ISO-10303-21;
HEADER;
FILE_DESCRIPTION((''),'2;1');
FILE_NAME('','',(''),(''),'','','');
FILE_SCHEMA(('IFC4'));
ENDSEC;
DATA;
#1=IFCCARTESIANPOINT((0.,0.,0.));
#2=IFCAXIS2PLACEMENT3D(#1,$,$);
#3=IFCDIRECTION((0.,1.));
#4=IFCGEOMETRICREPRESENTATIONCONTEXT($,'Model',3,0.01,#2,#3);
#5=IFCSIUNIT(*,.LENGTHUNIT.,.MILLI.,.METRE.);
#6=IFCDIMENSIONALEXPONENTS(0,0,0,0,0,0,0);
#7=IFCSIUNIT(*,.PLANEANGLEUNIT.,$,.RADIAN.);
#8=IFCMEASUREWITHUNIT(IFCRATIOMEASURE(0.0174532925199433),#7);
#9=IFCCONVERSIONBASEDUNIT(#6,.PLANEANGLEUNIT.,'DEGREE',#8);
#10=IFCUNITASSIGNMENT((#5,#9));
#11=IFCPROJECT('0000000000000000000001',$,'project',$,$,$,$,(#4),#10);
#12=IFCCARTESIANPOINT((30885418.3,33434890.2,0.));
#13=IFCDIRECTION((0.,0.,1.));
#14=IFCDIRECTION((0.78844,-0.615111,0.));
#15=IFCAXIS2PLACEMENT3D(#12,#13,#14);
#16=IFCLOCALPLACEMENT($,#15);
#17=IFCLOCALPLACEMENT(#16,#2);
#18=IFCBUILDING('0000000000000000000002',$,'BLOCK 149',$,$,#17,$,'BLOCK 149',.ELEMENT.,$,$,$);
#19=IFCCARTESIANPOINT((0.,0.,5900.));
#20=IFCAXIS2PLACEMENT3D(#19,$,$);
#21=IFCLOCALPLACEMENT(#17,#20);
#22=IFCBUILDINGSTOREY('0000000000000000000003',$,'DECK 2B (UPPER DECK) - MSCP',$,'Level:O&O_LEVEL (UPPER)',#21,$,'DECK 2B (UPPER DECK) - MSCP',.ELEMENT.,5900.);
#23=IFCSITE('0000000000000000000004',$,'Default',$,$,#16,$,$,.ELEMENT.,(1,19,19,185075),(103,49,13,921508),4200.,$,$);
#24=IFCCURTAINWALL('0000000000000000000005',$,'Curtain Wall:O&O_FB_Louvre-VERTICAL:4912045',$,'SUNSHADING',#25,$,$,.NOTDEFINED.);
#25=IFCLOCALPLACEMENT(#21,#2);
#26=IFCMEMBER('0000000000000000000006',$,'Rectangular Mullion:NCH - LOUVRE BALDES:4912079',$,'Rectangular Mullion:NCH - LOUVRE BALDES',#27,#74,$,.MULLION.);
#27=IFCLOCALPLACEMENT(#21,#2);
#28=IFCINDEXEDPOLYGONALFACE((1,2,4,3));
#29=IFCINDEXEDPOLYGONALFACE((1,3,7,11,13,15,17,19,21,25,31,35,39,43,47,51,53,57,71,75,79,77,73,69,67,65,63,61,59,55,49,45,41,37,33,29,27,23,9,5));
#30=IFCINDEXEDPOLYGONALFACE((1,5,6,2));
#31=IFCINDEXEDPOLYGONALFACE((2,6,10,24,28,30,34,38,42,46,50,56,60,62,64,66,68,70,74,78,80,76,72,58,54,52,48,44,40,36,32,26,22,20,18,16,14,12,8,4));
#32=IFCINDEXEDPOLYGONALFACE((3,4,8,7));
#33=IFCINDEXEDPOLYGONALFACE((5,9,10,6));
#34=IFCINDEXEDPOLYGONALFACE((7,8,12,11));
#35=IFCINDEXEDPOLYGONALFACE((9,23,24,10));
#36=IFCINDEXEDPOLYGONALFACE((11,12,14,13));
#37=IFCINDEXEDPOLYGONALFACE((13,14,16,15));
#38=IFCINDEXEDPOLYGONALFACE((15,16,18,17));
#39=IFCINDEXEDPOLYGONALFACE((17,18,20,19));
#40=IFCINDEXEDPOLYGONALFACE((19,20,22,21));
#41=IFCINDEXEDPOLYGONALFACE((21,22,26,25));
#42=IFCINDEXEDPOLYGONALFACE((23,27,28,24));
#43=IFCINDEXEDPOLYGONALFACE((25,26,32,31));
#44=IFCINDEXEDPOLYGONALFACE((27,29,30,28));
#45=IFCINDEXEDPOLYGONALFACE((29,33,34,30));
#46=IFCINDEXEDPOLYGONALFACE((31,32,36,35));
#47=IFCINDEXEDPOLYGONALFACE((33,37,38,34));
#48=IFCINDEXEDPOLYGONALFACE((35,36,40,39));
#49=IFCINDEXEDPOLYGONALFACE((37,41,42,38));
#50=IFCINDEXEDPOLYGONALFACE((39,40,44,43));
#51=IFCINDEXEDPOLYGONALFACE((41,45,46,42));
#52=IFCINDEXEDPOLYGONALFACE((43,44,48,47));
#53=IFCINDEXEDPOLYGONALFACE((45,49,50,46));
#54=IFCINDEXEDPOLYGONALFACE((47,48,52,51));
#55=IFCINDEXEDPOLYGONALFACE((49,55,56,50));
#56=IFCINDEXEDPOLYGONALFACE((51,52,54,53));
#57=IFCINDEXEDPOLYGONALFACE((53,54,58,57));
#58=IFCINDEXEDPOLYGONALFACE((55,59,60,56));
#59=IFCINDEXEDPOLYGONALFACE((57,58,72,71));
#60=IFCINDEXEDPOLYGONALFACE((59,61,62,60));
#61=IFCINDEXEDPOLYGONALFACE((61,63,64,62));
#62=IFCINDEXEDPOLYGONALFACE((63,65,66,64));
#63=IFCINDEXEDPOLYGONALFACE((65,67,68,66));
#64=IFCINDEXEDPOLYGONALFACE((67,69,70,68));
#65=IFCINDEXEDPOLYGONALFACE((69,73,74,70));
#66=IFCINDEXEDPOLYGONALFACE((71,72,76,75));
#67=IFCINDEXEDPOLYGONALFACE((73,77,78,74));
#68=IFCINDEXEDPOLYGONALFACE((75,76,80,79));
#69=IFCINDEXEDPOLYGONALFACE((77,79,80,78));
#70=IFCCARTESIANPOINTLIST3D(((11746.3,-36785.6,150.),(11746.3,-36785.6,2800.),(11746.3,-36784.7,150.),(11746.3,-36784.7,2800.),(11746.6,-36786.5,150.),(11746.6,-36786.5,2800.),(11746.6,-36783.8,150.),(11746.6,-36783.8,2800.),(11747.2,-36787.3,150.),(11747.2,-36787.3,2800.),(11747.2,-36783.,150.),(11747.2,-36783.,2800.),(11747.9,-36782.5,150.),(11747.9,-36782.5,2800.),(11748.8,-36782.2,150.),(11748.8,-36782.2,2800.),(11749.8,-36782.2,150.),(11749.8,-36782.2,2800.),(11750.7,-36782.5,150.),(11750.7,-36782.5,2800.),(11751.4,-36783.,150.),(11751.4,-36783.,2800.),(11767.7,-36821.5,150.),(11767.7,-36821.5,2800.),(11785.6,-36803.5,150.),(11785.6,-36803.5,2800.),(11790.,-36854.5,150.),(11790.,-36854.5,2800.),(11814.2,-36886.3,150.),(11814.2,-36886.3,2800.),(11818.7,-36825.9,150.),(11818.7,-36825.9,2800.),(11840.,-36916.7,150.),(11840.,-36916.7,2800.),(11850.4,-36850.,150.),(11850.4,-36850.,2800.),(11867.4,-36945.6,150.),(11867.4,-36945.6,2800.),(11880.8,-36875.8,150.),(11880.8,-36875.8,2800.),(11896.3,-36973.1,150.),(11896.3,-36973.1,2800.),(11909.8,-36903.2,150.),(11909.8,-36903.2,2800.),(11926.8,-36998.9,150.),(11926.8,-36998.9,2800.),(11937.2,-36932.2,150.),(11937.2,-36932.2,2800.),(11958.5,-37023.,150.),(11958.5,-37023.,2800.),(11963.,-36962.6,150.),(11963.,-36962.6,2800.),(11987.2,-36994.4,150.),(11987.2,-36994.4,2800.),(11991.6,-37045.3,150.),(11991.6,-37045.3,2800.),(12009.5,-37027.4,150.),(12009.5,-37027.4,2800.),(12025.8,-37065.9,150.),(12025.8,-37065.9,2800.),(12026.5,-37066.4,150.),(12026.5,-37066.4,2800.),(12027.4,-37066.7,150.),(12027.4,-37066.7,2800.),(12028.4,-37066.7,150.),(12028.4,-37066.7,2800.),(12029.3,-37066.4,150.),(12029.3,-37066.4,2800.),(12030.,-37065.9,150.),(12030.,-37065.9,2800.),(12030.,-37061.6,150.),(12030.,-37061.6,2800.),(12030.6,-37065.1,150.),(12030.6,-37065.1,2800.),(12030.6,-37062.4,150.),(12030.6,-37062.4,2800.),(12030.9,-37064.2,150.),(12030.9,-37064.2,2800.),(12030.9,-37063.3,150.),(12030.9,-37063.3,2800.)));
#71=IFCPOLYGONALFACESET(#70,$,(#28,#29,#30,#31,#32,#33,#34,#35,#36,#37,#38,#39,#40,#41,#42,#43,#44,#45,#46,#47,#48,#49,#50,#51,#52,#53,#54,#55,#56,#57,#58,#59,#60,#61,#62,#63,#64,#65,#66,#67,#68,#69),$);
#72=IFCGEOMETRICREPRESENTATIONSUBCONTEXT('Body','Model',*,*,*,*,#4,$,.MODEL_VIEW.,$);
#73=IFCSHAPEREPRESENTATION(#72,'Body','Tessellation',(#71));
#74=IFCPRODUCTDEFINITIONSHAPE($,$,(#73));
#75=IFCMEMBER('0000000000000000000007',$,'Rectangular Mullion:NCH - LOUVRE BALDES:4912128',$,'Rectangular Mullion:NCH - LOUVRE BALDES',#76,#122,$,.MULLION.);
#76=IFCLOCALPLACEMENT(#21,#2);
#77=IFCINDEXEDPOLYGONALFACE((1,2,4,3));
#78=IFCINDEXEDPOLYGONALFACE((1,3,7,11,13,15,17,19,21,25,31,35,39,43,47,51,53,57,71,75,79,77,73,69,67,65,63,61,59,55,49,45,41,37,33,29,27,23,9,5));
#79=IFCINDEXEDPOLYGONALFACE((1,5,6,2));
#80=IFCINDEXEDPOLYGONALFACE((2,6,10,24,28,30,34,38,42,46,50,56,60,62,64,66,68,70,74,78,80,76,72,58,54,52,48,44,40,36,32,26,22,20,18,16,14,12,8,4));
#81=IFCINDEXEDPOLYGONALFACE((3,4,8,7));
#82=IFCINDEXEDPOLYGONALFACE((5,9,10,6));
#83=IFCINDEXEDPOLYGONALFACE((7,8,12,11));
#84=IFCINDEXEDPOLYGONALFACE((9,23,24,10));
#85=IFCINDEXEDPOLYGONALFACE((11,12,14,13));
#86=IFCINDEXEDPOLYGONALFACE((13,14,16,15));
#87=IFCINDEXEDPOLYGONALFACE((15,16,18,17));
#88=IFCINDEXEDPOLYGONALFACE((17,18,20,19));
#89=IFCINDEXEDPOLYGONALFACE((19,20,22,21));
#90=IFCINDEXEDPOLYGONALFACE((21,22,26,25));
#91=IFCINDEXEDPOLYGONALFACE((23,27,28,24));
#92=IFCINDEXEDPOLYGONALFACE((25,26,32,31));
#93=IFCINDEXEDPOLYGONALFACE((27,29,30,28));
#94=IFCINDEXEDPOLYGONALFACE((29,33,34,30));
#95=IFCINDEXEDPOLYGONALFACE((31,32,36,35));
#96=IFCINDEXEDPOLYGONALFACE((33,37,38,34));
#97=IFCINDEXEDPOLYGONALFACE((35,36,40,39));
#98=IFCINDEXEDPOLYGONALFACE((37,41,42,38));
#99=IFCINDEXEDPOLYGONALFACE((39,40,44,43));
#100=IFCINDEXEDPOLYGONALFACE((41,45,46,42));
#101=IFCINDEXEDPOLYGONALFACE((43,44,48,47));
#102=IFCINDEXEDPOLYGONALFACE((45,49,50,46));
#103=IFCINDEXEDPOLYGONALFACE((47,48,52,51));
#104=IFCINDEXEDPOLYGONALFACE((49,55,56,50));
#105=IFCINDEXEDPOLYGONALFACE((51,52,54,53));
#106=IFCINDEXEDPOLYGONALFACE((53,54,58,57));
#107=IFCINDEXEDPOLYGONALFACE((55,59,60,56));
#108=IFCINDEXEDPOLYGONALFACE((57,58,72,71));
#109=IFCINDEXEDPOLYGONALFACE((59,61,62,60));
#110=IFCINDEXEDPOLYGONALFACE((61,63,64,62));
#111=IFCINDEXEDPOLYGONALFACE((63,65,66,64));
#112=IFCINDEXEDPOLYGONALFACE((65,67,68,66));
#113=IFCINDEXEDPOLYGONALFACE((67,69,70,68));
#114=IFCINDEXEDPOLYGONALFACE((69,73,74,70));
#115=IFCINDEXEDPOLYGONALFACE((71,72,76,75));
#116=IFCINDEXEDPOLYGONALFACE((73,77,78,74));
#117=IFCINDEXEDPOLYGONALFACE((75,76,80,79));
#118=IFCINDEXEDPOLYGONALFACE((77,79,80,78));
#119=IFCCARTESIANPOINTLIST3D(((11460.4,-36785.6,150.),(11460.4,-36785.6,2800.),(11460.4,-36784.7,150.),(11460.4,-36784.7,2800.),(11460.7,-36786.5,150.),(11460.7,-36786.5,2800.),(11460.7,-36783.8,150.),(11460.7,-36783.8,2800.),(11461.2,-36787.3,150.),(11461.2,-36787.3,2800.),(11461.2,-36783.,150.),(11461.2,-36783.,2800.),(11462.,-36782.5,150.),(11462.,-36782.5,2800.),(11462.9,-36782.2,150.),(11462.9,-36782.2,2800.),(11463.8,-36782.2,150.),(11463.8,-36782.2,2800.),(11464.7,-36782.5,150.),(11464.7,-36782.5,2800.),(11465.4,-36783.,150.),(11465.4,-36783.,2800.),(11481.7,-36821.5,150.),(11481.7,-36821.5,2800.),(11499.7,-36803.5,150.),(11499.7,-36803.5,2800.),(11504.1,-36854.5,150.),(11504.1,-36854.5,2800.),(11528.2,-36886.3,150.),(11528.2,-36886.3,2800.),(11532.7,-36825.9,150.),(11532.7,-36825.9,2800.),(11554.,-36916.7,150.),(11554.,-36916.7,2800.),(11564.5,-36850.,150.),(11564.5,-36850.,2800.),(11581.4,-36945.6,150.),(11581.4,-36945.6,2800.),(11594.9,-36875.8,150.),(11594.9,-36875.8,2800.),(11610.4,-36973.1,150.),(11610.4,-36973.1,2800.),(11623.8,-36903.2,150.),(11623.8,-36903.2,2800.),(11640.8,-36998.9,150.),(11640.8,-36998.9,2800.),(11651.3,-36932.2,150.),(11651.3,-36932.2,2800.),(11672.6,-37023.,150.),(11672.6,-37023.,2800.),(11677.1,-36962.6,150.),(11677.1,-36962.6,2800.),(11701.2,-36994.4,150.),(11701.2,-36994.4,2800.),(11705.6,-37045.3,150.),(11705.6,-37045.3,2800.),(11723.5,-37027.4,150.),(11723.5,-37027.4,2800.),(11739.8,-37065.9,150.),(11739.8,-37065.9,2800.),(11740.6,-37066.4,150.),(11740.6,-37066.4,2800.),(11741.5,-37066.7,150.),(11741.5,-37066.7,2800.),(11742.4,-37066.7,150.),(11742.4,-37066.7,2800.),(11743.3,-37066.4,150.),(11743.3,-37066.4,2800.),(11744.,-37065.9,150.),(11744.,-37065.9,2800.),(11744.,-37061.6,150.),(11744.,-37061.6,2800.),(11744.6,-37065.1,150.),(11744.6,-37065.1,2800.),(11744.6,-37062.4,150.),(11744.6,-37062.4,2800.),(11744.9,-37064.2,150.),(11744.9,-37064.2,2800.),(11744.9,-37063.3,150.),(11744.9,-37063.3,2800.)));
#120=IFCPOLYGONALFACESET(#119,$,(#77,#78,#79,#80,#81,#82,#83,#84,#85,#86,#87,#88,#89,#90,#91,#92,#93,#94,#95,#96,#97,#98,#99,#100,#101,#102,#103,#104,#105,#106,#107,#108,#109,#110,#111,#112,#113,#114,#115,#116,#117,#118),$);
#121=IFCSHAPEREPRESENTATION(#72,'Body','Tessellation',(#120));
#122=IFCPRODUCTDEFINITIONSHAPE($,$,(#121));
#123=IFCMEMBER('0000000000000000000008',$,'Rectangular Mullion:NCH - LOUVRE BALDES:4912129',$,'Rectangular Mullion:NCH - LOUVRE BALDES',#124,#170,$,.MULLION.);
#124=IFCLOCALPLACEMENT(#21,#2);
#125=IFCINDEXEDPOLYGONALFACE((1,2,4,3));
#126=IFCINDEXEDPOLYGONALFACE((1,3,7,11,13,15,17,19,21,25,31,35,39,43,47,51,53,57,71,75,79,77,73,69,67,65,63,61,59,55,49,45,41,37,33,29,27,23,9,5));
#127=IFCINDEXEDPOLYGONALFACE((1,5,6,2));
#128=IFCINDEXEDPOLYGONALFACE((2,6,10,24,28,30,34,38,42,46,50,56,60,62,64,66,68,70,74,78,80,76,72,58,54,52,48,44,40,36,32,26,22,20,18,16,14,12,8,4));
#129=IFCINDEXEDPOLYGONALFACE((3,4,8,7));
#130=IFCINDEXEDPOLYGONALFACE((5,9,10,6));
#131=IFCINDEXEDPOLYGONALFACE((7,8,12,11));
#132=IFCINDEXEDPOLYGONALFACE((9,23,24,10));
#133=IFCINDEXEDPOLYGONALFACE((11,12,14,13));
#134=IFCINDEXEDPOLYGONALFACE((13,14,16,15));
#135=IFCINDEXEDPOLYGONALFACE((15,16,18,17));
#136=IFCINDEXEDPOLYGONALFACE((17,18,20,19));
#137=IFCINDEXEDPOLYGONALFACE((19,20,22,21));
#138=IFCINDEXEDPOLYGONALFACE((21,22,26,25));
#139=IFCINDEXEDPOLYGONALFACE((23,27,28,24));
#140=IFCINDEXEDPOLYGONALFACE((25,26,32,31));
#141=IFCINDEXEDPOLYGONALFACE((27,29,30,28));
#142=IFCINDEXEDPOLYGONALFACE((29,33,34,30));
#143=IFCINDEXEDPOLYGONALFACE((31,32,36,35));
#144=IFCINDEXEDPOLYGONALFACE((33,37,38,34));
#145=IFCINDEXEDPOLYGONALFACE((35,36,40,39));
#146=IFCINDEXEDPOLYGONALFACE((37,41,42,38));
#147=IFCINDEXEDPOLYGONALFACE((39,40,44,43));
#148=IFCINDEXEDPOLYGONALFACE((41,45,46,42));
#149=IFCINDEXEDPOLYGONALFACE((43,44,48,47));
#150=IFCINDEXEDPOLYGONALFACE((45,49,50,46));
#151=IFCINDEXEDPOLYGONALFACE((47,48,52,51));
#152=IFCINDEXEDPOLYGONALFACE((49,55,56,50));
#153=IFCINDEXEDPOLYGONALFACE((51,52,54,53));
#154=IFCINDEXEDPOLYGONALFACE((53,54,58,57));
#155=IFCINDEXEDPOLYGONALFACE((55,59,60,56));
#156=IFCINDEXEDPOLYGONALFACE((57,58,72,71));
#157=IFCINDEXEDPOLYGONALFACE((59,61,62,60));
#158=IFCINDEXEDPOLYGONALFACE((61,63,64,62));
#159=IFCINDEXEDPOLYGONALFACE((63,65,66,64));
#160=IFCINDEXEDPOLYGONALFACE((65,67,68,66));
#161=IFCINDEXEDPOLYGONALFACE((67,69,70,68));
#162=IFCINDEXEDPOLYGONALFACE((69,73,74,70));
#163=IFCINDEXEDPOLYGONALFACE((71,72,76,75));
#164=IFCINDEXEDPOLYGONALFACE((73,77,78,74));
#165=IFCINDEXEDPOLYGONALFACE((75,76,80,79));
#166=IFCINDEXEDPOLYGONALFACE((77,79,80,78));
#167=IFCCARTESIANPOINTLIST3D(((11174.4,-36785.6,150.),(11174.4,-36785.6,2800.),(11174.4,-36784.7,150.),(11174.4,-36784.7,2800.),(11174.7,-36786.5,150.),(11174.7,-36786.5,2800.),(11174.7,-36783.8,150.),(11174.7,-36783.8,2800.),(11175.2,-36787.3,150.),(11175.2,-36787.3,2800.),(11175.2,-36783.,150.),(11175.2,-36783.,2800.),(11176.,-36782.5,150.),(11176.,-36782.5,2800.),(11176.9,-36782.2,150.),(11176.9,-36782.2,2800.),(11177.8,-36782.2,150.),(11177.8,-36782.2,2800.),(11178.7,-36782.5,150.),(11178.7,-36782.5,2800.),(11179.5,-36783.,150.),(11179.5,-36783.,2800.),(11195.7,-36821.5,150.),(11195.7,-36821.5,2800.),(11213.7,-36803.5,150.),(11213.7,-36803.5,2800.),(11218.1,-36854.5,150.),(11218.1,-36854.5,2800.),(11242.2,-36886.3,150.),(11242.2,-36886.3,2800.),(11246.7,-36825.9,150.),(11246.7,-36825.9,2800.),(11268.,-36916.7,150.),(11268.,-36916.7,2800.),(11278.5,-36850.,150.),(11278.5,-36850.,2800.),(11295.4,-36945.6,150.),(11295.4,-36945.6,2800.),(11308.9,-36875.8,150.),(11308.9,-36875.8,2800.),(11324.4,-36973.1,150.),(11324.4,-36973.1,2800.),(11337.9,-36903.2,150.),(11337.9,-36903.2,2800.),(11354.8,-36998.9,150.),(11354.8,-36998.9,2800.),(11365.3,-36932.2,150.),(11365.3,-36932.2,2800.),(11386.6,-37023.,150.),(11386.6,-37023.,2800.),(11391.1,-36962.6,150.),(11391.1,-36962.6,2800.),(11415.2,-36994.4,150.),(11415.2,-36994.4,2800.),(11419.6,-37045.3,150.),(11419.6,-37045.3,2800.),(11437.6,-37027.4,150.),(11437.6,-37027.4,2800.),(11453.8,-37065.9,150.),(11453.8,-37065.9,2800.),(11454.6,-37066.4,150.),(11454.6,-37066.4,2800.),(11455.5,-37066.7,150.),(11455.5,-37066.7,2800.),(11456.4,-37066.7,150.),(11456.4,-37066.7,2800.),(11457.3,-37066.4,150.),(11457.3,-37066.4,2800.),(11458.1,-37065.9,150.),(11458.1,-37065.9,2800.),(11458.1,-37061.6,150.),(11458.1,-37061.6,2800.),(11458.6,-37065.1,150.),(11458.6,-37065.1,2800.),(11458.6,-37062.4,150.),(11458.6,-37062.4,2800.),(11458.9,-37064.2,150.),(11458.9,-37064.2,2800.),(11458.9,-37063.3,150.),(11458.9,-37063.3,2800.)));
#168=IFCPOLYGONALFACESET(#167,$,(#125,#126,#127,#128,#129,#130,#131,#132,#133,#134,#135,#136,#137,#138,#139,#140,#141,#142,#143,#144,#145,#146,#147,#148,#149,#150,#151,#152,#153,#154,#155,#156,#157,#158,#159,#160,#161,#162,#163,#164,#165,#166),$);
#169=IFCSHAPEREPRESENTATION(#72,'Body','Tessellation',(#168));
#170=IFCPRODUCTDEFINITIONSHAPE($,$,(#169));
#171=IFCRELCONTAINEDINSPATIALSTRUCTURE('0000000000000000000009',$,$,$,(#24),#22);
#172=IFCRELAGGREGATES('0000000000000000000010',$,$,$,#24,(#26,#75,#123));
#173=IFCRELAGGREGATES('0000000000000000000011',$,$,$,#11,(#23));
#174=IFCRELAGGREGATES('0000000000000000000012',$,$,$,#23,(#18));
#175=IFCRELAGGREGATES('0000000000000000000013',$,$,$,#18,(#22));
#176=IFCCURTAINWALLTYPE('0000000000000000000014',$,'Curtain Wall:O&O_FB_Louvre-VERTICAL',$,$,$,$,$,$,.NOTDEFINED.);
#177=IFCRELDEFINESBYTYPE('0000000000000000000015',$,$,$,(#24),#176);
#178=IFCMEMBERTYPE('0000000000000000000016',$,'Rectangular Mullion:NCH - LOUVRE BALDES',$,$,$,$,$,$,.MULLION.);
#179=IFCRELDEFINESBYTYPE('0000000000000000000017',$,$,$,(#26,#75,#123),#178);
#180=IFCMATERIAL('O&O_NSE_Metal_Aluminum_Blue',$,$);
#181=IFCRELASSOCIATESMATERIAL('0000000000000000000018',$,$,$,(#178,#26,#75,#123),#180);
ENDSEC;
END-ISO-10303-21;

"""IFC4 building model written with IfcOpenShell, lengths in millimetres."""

from ifc_helpers import new_model, entity, si_unit, converted_unit, direction, frame, origin, place, context, subcontext, project, spatial, indexed_curve, outline, extrude, source, transform, mapped, material, type_object, type_shapes, element, aggregate, save


model = new_model("IFC4")

# Units and contexts
model_context = context("Model", 3, precision=0.01, world=origin(), true_north=direction((0.0, 1.0)))
body_context = subcontext(model_context, "Body", "Model", "MODEL_VIEW")
ifc_project = project(units=[si_unit("LENGTHUNIT", "METRE", prefix="MILLI"), converted_unit("PLANEANGLEUNIT", "DEGREE", entity("IfcRatioMeasure", 0.0174532925199433), si_unit("PLANEANGLEUNIT", "RADIAN"), dimensions=[0, 0, 0, 0, 0, 0, 0])], contexts=[model_context])

# Site, building, storey
site_placement = place(None, frame((30885418.3, 33434890.2, 0.0), z_axis=(0.0, 0.0, 1.0), x_axis=(0.78844, -0.615111, 0.0)))
site = spatial("IfcSite", under=ifc_project, at=site_placement, Name="Default", CompositionType="ELEMENT", RefLatitude=(1, 19, 19, 185075), RefLongitude=(103, 49, 13, 921508), RefElevation=4200.0)
building_placement = place(site_placement, origin())
building = spatial("IfcBuilding", under=site, at=building_placement, Name="BLOCK 149", LongName="BLOCK 149", CompositionType="ELEMENT")
storey_placement = place(building_placement, frame((0.0, 0.0, 5900.0)))
storey = spatial("IfcBuildingStorey", under=building, at=storey_placement, Name="DECK 2B (UPPER DECK) - MSCP", ObjectType="Level:O&O_LEVEL (UPPER)", LongName="DECK 2B (UPPER DECK) - MSCP", CompositionType="ELEMENT", Elevation=5900.0)

# Curtain wall, members
curtain_wall_type = type_object("IfcCurtainWallType", Name="Curtain Wall:O&O_FB_Louvre-VERTICAL", PredefinedType="NOTDEFINED")
curtain_wall_placement = place(storey_placement, frame((0.0, 0.0, -5900.0)))
curtain_wall = element("IfcCurtainWall", 1, at=curtain_wall_placement, inside=storey, type_object=curtain_wall_type, Name="Curtain Wall:O&O_FB_Louvre-VERTICAL:4912045", ObjectType="SUNSHADING", PredefinedType="NOTDEFINED")
placement = place(building_placement, origin())
ifc_material_1 = material(Name="O&O_NSE_Metal_Aluminum_Blue")
member_type_1 = type_object("IfcMemberType", Name="Rectangular Mullion:NCH - LOUVRE BALDES", PredefinedType="MULLION", material=ifc_material_1)
shared_shape_1 = source(origin(), body_context, "Body", "SweptSolid", [
    extrude(outline(indexed_curve([(55.9, -188.9), (54.8, -149.1), (51.6, -109.3), (46.1, -69.8), (38.6, -30.6), (28.9, 8.1), (17.1, 46.2), (3.3, 83.6), (-12.6, 120.2), (-30.4, 155.9), (-50.1, 190.5), (-50.5, 191.4), (-51.1, 192.1), (-52.0, 192.5), (-52.9, 192.7), (-53.8, 192.6), (-54.7, 192.2), (-55.4, 191.6), (-55.8, 190.8), (-56.0, 189.9), (-55.9, 188.9), (-54.8, 149.1), (-51.6, 109.3), (-46.1, 69.8), (-38.6, 30.6), (-28.9, -8.1), (-17.1, -46.2), (-3.3, -83.6), (12.6, -120.2), (30.4, -155.9), (50.1, -190.5), (50.5, -191.4), (51.1, -192.1), (52.0, -192.5), (52.9, -192.7), (53.8, -192.6), (54.7, -192.2), (55.4, -191.6), (55.8, -190.8), (56.0, -189.9), (55.9, -188.9)], self_intersect=False)), frame((0.0, 0.0, -2650.0), z_axis=(0.0, 0.0, 1.0), x_axis=(0.490779, -0.871284, 0.0)), (0.0, 0.0, 1.0), 2650.0),
])
type_shapes(member_type_1, [shared_shape_1])
member_1_placement = place(placement, frame((11888.6, -36924.4, 6050.0), z_axis=(0.0, 0.0, -1.0), x_axis=(-1.0, 0.0, 0.0)))
member_1 = element("IfcMember", 2, at=member_1_placement, type_object=member_type_1, material=ifc_material_1, Name="Rectangular Mullion:NCH - LOUVRE BALDES:4912079", ObjectType="Rectangular Mullion:NCH - LOUVRE BALDES", PredefinedType="MULLION", context=body_context, shape_type="MappedRepresentation", body=[
    mapped(shared_shape_1, transform((0.0, 0.0, 0.0), scale=1.0)),
])
member_2_placement = place(placement, frame((11602.6, -36924.4, 6050.0), z_axis=(0.0, 0.0, -1.0), x_axis=(-1.0, 0.0, 0.0)))
member_2 = element("IfcMember", 3, at=member_2_placement, type_object=member_type_1, material=ifc_material_1, Name="Rectangular Mullion:NCH - LOUVRE BALDES:4912128", ObjectType="Rectangular Mullion:NCH - LOUVRE BALDES", PredefinedType="MULLION", context=body_context, shape_type="MappedRepresentation", body=[
    mapped(shared_shape_1, transform((0.0, 0.0, 0.0), scale=1.0)),
])
member_3_placement = place(placement, frame((11316.6, -36924.4, 6050.0), z_axis=(0.0, 0.0, -1.0), x_axis=(-1.0, 0.0, 0.0)))
member_3 = element("IfcMember", 4, at=member_3_placement, type_object=member_type_1, material=ifc_material_1, Name="Rectangular Mullion:NCH - LOUVRE BALDES:4912129", ObjectType="Rectangular Mullion:NCH - LOUVRE BALDES", PredefinedType="MULLION", context=body_context, shape_type="MappedRepresentation", body=[
    mapped(shared_shape_1, transform((0.0, 0.0, 0.0), scale=1.0)),
])
aggregate(curtain_wall, [member_1, member_2, member_3])

save(model, "model.ifc")
